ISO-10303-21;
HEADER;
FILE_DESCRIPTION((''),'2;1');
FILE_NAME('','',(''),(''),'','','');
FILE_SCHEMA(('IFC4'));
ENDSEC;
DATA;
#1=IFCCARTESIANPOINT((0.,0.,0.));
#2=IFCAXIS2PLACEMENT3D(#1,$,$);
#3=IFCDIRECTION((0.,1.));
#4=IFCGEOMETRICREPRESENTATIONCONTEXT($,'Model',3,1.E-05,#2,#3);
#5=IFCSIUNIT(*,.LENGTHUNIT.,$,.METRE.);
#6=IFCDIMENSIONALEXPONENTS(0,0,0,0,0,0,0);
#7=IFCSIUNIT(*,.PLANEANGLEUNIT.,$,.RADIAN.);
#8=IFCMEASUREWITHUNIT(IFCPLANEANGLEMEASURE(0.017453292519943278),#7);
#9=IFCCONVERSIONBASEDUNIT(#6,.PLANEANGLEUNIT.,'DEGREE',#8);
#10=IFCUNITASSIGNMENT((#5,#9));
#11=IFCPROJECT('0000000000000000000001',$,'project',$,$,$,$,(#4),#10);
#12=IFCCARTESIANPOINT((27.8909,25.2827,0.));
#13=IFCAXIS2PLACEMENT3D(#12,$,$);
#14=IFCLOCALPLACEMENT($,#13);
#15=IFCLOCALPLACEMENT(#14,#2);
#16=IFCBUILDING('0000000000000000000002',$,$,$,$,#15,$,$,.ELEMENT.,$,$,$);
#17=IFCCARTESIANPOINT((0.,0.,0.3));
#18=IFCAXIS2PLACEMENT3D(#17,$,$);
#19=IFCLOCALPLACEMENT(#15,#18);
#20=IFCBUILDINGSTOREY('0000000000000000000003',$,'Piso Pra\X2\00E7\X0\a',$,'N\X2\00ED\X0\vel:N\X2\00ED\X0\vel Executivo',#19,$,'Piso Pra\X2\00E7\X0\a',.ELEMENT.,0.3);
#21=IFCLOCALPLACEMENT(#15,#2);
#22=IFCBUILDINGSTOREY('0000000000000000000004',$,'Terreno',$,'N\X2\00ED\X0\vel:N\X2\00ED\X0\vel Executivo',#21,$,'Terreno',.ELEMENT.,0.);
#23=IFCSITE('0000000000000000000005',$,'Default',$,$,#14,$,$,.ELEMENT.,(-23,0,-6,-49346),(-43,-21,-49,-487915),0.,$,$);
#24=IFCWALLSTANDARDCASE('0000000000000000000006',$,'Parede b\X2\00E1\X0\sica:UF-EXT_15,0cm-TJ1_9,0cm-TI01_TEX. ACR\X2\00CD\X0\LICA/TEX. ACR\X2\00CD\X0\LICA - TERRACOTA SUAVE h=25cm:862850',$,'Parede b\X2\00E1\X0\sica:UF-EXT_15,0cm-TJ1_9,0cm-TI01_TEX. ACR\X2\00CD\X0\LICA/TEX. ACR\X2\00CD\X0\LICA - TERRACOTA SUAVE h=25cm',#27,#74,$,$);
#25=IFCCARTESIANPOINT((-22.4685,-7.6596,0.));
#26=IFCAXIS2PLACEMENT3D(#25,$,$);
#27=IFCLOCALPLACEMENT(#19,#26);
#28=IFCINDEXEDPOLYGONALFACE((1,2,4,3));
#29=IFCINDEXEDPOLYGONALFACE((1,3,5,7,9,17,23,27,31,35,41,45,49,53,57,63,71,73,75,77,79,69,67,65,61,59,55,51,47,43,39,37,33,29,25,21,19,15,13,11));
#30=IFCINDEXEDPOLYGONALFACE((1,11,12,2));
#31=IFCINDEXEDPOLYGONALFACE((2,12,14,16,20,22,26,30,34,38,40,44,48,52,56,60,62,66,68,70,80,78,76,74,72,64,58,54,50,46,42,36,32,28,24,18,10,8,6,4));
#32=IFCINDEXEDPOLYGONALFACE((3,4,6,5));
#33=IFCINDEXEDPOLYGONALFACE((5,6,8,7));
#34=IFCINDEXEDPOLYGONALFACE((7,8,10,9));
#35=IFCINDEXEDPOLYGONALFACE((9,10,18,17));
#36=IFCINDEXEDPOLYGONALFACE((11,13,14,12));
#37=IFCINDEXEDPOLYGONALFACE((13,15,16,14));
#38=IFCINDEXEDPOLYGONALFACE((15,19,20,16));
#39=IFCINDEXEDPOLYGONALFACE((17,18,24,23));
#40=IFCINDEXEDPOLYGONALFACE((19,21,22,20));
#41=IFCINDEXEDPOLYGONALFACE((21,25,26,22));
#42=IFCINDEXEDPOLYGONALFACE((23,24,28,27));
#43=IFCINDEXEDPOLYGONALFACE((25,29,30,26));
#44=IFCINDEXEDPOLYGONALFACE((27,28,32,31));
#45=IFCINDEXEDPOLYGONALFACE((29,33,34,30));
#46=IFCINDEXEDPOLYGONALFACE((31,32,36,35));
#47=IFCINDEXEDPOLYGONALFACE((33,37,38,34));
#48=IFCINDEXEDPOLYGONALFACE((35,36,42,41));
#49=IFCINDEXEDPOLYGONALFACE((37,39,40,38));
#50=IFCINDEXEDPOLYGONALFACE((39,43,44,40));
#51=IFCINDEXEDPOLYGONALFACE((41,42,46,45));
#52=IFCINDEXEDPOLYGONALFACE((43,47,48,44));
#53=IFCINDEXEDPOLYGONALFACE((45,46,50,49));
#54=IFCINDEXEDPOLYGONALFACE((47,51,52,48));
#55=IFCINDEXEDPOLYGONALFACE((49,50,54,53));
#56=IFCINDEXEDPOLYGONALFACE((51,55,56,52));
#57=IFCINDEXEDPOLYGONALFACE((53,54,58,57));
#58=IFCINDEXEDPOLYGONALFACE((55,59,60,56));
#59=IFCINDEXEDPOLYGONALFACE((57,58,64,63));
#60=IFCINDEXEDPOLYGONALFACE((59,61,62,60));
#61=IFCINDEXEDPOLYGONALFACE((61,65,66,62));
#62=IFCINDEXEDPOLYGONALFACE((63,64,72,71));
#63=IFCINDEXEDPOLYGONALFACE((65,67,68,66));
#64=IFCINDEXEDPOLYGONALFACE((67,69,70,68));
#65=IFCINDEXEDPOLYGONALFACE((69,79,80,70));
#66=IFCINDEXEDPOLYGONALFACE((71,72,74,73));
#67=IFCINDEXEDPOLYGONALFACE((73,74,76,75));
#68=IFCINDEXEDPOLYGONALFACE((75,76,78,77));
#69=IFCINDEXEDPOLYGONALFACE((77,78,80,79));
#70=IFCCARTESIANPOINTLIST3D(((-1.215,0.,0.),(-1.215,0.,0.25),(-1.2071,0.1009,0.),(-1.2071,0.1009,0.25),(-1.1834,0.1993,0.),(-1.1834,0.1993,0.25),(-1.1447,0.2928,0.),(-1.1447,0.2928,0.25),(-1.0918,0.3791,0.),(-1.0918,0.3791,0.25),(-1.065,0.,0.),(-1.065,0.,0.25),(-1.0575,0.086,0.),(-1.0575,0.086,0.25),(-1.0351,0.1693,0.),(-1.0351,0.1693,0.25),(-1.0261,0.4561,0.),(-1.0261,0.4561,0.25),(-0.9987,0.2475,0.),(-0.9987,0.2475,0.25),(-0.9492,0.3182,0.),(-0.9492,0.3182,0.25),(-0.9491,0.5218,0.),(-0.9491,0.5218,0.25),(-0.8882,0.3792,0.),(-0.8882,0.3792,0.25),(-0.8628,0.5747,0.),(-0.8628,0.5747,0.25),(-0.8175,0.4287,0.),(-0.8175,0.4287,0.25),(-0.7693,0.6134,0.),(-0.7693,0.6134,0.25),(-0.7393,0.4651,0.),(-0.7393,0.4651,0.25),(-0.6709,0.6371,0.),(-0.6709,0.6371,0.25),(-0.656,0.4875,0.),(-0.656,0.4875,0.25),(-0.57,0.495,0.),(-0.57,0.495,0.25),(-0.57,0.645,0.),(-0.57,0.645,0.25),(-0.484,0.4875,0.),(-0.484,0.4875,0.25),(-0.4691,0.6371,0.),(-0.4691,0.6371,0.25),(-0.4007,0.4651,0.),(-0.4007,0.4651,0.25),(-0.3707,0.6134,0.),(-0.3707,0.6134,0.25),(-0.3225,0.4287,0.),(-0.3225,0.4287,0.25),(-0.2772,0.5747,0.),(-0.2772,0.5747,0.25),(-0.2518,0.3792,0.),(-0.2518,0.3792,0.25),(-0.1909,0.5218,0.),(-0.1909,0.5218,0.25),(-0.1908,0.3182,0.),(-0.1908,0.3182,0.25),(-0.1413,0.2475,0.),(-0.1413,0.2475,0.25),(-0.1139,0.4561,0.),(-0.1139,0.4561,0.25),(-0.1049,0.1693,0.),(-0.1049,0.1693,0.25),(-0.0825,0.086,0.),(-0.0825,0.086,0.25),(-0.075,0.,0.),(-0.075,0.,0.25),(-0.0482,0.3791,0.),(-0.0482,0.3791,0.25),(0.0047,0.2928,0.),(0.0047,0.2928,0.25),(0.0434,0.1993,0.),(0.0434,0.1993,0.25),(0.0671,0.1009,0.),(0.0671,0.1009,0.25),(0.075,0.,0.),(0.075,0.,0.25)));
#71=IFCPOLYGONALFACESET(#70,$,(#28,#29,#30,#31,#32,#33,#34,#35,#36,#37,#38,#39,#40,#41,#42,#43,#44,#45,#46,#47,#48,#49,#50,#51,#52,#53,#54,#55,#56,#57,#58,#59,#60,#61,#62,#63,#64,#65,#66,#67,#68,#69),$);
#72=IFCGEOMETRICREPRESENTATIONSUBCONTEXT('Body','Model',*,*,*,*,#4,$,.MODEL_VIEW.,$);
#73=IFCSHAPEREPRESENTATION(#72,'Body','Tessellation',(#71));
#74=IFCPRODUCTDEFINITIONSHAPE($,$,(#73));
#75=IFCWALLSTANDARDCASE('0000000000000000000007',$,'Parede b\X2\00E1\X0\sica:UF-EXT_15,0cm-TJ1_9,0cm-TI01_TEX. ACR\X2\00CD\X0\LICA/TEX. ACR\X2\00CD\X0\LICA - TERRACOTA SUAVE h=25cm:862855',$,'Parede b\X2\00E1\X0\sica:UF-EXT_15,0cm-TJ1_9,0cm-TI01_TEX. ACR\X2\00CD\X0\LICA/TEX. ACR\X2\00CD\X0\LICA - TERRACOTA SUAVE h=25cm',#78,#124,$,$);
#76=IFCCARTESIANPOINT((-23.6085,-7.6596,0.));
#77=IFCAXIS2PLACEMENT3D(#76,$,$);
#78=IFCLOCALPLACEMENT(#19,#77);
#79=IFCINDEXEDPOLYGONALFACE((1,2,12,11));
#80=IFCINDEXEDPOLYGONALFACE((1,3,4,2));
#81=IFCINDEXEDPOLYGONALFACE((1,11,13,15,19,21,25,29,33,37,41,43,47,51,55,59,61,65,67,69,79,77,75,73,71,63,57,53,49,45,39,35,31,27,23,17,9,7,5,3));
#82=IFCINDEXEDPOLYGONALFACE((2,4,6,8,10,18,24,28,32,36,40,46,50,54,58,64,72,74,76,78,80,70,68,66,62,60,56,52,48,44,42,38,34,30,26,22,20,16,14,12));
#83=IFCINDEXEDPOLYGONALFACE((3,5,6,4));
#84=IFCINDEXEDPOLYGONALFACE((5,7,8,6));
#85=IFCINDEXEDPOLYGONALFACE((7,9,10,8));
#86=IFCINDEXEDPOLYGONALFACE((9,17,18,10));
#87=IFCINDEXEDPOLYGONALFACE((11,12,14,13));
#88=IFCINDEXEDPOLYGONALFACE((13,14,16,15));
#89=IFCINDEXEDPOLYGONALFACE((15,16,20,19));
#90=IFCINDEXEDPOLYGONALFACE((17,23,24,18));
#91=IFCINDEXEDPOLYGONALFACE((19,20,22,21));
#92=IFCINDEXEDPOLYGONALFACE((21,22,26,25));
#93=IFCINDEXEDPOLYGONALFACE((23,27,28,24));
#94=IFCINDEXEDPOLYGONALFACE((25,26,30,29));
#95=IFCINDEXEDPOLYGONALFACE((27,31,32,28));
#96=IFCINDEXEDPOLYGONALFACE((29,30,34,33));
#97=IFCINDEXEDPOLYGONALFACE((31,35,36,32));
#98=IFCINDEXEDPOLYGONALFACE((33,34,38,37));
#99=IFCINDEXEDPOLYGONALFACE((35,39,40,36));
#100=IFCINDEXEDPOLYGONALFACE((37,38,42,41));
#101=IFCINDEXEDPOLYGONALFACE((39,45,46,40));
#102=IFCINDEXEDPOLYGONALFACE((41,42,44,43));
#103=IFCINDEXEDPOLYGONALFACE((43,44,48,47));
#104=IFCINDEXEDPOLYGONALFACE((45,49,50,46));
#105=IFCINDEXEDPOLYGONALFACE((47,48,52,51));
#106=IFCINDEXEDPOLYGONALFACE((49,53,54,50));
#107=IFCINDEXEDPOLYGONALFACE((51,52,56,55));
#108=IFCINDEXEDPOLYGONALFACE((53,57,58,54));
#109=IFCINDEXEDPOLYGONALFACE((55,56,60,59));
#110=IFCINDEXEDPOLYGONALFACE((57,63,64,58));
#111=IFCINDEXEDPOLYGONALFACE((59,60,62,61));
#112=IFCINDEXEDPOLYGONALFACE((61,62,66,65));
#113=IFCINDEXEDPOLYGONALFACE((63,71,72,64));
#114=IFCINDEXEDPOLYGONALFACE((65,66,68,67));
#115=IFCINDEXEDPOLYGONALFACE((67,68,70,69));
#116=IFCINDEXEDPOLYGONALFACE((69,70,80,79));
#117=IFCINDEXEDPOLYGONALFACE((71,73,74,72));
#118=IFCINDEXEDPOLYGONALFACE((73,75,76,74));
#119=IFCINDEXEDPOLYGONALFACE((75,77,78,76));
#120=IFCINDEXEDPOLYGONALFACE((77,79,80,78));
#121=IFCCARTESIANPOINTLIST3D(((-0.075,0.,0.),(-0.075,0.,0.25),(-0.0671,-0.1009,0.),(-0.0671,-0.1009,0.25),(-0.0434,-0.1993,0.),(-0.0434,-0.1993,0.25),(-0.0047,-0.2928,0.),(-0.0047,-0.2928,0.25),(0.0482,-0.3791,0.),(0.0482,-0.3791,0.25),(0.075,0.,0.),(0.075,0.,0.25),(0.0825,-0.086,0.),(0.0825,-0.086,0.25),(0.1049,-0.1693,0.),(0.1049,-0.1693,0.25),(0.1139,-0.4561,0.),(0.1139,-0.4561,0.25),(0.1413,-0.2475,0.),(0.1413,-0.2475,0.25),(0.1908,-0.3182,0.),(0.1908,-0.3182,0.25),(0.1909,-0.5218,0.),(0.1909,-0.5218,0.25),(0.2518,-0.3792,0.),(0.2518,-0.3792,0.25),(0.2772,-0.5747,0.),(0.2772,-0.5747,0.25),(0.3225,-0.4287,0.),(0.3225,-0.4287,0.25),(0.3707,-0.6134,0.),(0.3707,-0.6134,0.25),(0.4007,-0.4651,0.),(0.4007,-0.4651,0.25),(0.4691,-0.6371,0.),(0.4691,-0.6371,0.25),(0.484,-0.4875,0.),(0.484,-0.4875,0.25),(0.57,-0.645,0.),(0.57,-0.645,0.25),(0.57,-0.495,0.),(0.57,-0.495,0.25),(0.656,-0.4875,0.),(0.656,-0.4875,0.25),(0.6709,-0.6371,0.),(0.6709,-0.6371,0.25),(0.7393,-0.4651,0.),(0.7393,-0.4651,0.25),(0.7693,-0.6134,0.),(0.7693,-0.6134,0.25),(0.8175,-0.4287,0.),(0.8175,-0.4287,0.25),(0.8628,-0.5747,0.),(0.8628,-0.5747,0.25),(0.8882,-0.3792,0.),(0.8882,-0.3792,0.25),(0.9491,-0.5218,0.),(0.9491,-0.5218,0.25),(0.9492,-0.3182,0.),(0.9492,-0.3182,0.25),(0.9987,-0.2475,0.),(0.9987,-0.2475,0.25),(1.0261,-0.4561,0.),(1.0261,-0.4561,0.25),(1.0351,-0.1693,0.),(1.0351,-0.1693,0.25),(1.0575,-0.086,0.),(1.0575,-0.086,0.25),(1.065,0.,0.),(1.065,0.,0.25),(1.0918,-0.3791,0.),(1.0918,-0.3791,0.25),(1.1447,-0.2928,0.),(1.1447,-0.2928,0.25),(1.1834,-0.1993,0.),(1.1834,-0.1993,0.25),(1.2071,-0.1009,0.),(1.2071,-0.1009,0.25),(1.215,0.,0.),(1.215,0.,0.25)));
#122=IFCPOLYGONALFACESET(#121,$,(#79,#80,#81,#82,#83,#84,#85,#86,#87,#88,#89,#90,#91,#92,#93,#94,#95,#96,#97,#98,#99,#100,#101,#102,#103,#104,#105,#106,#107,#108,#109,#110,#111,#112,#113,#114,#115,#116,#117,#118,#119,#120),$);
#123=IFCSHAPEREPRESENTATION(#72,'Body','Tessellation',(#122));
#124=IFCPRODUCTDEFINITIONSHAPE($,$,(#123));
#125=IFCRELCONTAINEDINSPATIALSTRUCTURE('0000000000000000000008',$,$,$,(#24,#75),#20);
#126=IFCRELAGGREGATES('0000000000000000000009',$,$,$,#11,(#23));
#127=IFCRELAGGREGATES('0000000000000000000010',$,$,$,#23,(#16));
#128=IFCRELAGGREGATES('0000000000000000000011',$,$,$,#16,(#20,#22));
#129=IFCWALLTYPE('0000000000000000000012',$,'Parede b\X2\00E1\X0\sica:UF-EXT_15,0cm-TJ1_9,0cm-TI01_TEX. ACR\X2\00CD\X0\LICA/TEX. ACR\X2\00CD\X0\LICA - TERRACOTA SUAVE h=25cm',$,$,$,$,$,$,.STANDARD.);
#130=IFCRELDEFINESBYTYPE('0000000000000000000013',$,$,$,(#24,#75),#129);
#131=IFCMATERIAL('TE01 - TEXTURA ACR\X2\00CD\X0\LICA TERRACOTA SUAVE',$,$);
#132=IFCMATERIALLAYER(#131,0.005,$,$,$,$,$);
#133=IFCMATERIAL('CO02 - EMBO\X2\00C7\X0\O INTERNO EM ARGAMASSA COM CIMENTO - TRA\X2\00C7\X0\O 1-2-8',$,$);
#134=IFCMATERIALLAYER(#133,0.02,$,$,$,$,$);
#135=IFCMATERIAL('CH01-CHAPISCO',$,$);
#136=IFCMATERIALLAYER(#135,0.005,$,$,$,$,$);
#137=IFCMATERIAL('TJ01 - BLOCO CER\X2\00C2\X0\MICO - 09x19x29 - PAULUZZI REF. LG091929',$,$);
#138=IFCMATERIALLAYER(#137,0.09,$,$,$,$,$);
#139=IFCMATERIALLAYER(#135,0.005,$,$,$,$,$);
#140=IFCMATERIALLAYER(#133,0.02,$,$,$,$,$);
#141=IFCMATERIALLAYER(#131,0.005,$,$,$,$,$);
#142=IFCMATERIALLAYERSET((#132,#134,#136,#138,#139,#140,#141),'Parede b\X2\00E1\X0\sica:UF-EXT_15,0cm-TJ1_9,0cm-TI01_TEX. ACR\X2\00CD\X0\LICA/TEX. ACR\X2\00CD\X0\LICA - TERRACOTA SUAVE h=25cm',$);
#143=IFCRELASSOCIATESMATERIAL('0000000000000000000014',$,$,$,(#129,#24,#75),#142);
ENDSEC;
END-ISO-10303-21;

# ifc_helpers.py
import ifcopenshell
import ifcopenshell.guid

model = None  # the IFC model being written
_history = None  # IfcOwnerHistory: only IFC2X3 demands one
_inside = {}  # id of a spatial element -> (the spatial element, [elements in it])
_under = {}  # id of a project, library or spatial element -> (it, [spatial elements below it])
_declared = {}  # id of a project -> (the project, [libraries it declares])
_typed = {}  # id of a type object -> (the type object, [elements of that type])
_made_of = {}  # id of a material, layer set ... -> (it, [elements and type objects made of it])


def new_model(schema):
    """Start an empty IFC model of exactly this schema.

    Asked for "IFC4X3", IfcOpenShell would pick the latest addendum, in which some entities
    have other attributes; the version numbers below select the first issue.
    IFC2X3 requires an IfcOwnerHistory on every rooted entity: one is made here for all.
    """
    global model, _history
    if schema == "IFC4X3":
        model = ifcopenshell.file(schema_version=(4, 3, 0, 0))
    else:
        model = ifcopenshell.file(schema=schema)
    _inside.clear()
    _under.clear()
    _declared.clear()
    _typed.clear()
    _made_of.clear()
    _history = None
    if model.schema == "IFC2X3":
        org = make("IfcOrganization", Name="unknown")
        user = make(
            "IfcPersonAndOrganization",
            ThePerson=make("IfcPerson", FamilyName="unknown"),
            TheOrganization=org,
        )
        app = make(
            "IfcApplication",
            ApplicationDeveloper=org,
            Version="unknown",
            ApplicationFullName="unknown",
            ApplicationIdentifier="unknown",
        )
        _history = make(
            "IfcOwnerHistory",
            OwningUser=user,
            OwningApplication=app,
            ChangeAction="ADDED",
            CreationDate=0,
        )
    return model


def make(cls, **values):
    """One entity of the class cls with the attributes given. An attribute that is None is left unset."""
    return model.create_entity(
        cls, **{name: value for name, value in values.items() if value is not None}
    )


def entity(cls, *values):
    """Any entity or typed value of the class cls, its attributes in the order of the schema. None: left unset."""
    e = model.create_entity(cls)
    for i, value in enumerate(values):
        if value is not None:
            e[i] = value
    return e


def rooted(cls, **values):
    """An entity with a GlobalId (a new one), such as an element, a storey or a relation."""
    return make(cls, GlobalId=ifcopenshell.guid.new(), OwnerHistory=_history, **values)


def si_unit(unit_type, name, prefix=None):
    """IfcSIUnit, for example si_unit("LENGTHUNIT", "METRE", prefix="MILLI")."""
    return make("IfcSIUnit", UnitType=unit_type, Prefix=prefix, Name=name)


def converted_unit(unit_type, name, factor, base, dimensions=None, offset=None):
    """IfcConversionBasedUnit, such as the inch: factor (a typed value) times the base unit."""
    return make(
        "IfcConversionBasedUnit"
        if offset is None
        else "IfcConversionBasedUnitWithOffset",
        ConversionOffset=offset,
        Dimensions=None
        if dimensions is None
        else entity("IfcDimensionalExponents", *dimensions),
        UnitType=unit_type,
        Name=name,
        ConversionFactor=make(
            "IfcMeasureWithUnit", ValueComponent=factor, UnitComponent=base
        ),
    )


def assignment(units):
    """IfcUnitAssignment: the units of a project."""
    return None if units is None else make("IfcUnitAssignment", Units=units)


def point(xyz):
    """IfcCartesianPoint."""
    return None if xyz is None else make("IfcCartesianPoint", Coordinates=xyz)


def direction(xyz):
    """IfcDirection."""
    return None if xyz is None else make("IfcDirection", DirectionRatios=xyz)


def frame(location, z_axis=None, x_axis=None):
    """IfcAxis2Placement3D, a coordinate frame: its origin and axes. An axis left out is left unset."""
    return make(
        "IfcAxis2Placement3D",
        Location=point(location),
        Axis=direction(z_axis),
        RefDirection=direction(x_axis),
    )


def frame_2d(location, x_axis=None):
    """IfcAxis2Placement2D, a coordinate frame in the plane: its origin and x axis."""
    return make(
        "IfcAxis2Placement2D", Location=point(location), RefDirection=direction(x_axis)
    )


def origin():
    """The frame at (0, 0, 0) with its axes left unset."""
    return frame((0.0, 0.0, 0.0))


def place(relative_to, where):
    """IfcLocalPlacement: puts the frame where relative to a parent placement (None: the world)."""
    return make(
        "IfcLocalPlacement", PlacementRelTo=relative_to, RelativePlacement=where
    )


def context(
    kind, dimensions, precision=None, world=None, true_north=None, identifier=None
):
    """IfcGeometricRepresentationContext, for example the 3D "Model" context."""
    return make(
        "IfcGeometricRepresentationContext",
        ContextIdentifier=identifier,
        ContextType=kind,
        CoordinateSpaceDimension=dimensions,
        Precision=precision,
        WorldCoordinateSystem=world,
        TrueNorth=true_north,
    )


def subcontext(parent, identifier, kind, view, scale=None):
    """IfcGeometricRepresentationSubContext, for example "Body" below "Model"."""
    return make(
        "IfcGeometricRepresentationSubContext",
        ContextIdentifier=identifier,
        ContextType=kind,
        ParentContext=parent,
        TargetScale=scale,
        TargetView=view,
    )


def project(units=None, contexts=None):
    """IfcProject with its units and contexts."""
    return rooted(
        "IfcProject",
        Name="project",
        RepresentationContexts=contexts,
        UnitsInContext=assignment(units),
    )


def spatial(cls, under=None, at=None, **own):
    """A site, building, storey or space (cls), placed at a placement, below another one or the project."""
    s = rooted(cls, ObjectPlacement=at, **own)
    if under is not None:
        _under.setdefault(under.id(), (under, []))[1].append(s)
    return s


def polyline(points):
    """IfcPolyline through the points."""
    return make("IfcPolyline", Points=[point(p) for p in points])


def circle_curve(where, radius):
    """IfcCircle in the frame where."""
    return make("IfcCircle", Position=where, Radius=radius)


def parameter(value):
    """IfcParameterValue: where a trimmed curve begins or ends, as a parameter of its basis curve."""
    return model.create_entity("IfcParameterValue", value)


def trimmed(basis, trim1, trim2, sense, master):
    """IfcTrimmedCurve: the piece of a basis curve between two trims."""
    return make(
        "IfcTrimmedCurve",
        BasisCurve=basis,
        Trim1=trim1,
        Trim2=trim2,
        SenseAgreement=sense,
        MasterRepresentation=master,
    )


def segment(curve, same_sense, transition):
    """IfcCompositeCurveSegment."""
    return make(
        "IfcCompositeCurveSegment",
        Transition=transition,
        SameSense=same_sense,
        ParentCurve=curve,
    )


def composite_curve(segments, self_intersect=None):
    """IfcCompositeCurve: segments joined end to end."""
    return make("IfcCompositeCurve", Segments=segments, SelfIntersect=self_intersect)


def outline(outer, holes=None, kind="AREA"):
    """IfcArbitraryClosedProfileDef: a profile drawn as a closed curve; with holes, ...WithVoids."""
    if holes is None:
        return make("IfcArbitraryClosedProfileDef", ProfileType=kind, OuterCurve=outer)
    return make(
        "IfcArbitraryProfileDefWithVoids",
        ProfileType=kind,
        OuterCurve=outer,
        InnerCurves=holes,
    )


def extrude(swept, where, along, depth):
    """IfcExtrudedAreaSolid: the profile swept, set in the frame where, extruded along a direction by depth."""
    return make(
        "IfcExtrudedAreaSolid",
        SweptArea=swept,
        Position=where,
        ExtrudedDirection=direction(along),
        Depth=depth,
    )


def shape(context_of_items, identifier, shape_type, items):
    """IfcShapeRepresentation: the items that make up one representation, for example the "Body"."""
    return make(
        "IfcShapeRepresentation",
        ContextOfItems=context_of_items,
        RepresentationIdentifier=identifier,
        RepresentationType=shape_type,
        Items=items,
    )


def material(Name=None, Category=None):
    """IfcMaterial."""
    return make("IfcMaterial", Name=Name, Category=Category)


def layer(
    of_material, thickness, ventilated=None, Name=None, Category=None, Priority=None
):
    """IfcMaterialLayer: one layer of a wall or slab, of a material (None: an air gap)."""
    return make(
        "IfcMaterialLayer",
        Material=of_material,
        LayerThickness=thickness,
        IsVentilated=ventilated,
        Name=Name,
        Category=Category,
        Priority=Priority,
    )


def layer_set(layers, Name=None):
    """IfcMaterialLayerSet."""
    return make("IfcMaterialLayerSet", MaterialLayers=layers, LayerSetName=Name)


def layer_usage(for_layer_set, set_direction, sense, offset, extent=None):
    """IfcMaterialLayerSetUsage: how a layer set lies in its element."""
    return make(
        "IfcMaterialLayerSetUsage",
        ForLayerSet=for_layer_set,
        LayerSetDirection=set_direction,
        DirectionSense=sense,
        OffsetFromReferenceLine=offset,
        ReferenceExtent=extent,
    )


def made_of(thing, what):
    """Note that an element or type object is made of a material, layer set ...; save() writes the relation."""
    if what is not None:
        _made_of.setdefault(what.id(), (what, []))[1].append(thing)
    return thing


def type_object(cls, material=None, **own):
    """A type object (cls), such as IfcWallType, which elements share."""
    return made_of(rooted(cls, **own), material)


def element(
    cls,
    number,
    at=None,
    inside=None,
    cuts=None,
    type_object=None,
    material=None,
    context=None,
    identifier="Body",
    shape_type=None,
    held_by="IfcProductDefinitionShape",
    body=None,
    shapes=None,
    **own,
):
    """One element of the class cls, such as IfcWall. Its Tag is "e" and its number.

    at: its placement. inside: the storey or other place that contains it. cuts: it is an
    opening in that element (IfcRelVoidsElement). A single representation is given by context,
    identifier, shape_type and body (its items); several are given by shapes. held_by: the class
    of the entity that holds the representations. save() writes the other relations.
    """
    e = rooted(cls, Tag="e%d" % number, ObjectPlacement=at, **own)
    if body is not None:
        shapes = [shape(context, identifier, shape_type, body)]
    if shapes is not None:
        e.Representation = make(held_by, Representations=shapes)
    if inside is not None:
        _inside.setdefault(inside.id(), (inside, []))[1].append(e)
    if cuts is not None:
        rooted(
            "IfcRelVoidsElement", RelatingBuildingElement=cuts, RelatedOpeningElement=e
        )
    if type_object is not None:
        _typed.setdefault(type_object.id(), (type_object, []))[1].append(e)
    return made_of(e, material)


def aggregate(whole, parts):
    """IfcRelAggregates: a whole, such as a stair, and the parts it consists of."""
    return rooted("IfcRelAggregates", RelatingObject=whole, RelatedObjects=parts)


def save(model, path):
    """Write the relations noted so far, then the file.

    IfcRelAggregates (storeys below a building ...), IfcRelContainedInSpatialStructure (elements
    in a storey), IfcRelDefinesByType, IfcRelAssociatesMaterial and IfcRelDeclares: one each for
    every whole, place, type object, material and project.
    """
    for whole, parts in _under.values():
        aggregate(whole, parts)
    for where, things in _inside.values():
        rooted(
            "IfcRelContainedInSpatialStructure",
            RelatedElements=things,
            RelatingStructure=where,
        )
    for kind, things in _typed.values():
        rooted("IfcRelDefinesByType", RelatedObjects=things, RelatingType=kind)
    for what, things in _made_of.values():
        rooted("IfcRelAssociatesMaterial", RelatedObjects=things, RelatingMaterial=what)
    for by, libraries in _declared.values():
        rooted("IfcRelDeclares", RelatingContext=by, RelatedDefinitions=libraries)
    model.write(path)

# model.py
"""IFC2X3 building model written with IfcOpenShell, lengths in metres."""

from ifc_helpers import new_model, entity, si_unit, converted_unit, direction, frame, frame_2d, origin, place, context, subcontext, project, spatial, polyline, circle_curve, parameter, trimmed, segment, composite_curve, outline, extrude, material, layer, layer_set, layer_usage, type_object, element, save


model = new_model("IFC2X3")

# Units and contexts
model_context = context("Model", 3, precision=1e-05, world=origin(), true_north=direction((0.0, 1.0)))
body_context = subcontext(model_context, "Body", "Model", "MODEL_VIEW")
ifc_project = project(units=[si_unit("LENGTHUNIT", "METRE"), converted_unit("PLANEANGLEUNIT", "DEGREE", entity("IfcPlaneAngleMeasure", 0.017453292519943278), si_unit("PLANEANGLEUNIT", "RADIAN"), dimensions=[0, 0, 0, 0, 0, 0, 0])], contexts=[model_context])

# Site, building, storey
site_placement = place(None, frame((27.8909, 25.2827, 0.0)))
site = spatial("IfcSite", under=ifc_project, at=site_placement, Name="Default", CompositionType="ELEMENT", RefLatitude=(-23, 0, -6, -49346), RefLongitude=(-43, -21, -49, -487915), RefElevation=0.0)
building_placement = place(site_placement, origin())
building = spatial("IfcBuilding", under=site, at=building_placement, CompositionType="ELEMENT")
storey_1_placement = place(building_placement, frame((0.0, 0.0, 0.3)))
storey_1 = spatial("IfcBuildingStorey", under=building, at=storey_1_placement, Name="Piso Praça", ObjectType="Nível:Nível Executivo", LongName="Piso Praça", CompositionType="ELEMENT", Elevation=0.3)

# Walls
ifc_material_1 = material(Name="CO02 - EMBOÇO INTERNO EM ARGAMASSA COM CIMENTO - TRAÇO 1-2-8")
ifc_material_2 = material(Name="CH01-CHAPISCO")
ifc_material_3 = material(Name="TJ01 - BLOCO CERÂMICO - 09x19x29 - PAULUZZI REF. LG091929")
ifc_material_4 = material(Name="TE01 - TEXTURA ACRÍLICA TERRACOTA SUAVE")
ifc_layer_1 = layer(ifc_material_4, 0.005)
ifc_layer_2 = layer(ifc_material_1, 0.02)
ifc_layer_3 = layer(ifc_material_2, 0.005)
ifc_layer_4 = layer(ifc_material_3, 0.09)
ifc_layer_5 = layer(ifc_material_2, 0.005)
ifc_layer_6 = layer(ifc_material_1, 0.02)
ifc_layer_7 = layer(ifc_material_4, 0.005)
ifc_layer_set_1 = layer_set([ifc_layer_1, ifc_layer_2, ifc_layer_3, ifc_layer_4, ifc_layer_5, ifc_layer_6, ifc_layer_7], Name="Parede básica:UF-EXT_15,0cm-TJ1_9,0cm-TI01_TEX. ACRÍLICA/TEX. ACRÍLICA - TERRACOTA SUAVE h=25cm")
ifc_layer_usage_1 = layer_usage(ifc_layer_set_1, "AXIS2", "NEGATIVE", 0.075)
wall_type_1 = type_object("IfcWallType", Name="Parede básica:UF-EXT_15,0cm-TJ1_9,0cm-TI01_TEX. ACRÍLICA/TEX. ACRÍLICA - TERRACOTA SUAVE h=25cm", PredefinedType="STANDARD", material=ifc_layer_set_1)
wall_1_placement = place(storey_1_placement, frame((-22.4685, -7.6596, 0.0)))
element("IfcWallStandardCase", 1, at=wall_1_placement, inside=storey_1, type_object=wall_type_1, material=ifc_layer_usage_1, Name="Parede básica:UF-EXT_15,0cm-TJ1_9,0cm-TI01_TEX. ACRÍLICA/TEX. ACRÍLICA - TERRACOTA SUAVE h=25cm:862850", ObjectType="Parede básica:UF-EXT_15,0cm-TJ1_9,0cm-TI01_TEX. ACRÍLICA/TEX. ACRÍLICA - TERRACOTA SUAVE h=25cm", context=body_context, shape_type="SweptSolid", body=[
    extrude(outline(composite_curve([segment(trimmed(circle_curve(frame_2d((-0.57, 0.0), x_axis=(1.0, 0.0)), 0.495), [parameter(0.0)], [parameter(180.0)], True, "PARAMETER"), False, "CONTINUOUS"), segment(polyline([(-0.075, 0.0), (0.075, 0.0)]), True, "CONTINUOUS"), segment(trimmed(circle_curve(frame_2d((-0.57, 0.0), x_axis=(1.0, 0.0)), 0.645), [parameter(0.0)], [parameter(180.0)], True, "PARAMETER"), True, "CONTINUOUS"), segment(polyline([(-1.215, 0.0), (-1.065, 0.0)]), True, "CONTINUOUS")], self_intersect=False)), origin(), (0.0, 0.0, 1.0), 0.25),
])
wall_2_placement = place(storey_1_placement, frame((-23.6085, -7.6596, 0.0)))
element("IfcWallStandardCase", 2, at=wall_2_placement, inside=storey_1, type_object=wall_type_1, material=ifc_layer_usage_1, Name="Parede básica:UF-EXT_15,0cm-TJ1_9,0cm-TI01_TEX. ACRÍLICA/TEX. ACRÍLICA - TERRACOTA SUAVE h=25cm:862855", ObjectType="Parede básica:UF-EXT_15,0cm-TJ1_9,0cm-TI01_TEX. ACRÍLICA/TEX. ACRÍLICA - TERRACOTA SUAVE h=25cm", context=body_context, shape_type="SweptSolid", body=[
    extrude(outline(composite_curve([segment(trimmed(circle_curve(frame_2d((0.57, 0.0), x_axis=(1.0, 0.0)), 0.495), [parameter(180.0)], [parameter(0.0)], True, "PARAMETER"), False, "CONTINUOUS"), segment(polyline([(0.075, 0.0), (-0.075, 0.0)]), True, "CONTINUOUS"), segment(trimmed(circle_curve(frame_2d((0.57, 0.0), x_axis=(1.0, 0.0)), 0.645), [parameter(180.0)], [parameter(0.0)], True, "PARAMETER"), True, "CONTINUOUS"), segment(polyline([(1.215, 0.0), (1.065, 0.0)]), True, "CONTINUOUS")], self_intersect=False)), origin(), (0.0, 0.0, 1.0), 0.25),
])

# Shared definitions
storey_2_placement = place(building_placement, origin())
storey_2 = spatial("IfcBuildingStorey", under=building, at=storey_2_placement, Name="Terreno", ObjectType="Nível:Nível Executivo", LongName="Terreno", CompositionType="ELEMENT", Elevation=0.0)

save(model, "model.ifc")
